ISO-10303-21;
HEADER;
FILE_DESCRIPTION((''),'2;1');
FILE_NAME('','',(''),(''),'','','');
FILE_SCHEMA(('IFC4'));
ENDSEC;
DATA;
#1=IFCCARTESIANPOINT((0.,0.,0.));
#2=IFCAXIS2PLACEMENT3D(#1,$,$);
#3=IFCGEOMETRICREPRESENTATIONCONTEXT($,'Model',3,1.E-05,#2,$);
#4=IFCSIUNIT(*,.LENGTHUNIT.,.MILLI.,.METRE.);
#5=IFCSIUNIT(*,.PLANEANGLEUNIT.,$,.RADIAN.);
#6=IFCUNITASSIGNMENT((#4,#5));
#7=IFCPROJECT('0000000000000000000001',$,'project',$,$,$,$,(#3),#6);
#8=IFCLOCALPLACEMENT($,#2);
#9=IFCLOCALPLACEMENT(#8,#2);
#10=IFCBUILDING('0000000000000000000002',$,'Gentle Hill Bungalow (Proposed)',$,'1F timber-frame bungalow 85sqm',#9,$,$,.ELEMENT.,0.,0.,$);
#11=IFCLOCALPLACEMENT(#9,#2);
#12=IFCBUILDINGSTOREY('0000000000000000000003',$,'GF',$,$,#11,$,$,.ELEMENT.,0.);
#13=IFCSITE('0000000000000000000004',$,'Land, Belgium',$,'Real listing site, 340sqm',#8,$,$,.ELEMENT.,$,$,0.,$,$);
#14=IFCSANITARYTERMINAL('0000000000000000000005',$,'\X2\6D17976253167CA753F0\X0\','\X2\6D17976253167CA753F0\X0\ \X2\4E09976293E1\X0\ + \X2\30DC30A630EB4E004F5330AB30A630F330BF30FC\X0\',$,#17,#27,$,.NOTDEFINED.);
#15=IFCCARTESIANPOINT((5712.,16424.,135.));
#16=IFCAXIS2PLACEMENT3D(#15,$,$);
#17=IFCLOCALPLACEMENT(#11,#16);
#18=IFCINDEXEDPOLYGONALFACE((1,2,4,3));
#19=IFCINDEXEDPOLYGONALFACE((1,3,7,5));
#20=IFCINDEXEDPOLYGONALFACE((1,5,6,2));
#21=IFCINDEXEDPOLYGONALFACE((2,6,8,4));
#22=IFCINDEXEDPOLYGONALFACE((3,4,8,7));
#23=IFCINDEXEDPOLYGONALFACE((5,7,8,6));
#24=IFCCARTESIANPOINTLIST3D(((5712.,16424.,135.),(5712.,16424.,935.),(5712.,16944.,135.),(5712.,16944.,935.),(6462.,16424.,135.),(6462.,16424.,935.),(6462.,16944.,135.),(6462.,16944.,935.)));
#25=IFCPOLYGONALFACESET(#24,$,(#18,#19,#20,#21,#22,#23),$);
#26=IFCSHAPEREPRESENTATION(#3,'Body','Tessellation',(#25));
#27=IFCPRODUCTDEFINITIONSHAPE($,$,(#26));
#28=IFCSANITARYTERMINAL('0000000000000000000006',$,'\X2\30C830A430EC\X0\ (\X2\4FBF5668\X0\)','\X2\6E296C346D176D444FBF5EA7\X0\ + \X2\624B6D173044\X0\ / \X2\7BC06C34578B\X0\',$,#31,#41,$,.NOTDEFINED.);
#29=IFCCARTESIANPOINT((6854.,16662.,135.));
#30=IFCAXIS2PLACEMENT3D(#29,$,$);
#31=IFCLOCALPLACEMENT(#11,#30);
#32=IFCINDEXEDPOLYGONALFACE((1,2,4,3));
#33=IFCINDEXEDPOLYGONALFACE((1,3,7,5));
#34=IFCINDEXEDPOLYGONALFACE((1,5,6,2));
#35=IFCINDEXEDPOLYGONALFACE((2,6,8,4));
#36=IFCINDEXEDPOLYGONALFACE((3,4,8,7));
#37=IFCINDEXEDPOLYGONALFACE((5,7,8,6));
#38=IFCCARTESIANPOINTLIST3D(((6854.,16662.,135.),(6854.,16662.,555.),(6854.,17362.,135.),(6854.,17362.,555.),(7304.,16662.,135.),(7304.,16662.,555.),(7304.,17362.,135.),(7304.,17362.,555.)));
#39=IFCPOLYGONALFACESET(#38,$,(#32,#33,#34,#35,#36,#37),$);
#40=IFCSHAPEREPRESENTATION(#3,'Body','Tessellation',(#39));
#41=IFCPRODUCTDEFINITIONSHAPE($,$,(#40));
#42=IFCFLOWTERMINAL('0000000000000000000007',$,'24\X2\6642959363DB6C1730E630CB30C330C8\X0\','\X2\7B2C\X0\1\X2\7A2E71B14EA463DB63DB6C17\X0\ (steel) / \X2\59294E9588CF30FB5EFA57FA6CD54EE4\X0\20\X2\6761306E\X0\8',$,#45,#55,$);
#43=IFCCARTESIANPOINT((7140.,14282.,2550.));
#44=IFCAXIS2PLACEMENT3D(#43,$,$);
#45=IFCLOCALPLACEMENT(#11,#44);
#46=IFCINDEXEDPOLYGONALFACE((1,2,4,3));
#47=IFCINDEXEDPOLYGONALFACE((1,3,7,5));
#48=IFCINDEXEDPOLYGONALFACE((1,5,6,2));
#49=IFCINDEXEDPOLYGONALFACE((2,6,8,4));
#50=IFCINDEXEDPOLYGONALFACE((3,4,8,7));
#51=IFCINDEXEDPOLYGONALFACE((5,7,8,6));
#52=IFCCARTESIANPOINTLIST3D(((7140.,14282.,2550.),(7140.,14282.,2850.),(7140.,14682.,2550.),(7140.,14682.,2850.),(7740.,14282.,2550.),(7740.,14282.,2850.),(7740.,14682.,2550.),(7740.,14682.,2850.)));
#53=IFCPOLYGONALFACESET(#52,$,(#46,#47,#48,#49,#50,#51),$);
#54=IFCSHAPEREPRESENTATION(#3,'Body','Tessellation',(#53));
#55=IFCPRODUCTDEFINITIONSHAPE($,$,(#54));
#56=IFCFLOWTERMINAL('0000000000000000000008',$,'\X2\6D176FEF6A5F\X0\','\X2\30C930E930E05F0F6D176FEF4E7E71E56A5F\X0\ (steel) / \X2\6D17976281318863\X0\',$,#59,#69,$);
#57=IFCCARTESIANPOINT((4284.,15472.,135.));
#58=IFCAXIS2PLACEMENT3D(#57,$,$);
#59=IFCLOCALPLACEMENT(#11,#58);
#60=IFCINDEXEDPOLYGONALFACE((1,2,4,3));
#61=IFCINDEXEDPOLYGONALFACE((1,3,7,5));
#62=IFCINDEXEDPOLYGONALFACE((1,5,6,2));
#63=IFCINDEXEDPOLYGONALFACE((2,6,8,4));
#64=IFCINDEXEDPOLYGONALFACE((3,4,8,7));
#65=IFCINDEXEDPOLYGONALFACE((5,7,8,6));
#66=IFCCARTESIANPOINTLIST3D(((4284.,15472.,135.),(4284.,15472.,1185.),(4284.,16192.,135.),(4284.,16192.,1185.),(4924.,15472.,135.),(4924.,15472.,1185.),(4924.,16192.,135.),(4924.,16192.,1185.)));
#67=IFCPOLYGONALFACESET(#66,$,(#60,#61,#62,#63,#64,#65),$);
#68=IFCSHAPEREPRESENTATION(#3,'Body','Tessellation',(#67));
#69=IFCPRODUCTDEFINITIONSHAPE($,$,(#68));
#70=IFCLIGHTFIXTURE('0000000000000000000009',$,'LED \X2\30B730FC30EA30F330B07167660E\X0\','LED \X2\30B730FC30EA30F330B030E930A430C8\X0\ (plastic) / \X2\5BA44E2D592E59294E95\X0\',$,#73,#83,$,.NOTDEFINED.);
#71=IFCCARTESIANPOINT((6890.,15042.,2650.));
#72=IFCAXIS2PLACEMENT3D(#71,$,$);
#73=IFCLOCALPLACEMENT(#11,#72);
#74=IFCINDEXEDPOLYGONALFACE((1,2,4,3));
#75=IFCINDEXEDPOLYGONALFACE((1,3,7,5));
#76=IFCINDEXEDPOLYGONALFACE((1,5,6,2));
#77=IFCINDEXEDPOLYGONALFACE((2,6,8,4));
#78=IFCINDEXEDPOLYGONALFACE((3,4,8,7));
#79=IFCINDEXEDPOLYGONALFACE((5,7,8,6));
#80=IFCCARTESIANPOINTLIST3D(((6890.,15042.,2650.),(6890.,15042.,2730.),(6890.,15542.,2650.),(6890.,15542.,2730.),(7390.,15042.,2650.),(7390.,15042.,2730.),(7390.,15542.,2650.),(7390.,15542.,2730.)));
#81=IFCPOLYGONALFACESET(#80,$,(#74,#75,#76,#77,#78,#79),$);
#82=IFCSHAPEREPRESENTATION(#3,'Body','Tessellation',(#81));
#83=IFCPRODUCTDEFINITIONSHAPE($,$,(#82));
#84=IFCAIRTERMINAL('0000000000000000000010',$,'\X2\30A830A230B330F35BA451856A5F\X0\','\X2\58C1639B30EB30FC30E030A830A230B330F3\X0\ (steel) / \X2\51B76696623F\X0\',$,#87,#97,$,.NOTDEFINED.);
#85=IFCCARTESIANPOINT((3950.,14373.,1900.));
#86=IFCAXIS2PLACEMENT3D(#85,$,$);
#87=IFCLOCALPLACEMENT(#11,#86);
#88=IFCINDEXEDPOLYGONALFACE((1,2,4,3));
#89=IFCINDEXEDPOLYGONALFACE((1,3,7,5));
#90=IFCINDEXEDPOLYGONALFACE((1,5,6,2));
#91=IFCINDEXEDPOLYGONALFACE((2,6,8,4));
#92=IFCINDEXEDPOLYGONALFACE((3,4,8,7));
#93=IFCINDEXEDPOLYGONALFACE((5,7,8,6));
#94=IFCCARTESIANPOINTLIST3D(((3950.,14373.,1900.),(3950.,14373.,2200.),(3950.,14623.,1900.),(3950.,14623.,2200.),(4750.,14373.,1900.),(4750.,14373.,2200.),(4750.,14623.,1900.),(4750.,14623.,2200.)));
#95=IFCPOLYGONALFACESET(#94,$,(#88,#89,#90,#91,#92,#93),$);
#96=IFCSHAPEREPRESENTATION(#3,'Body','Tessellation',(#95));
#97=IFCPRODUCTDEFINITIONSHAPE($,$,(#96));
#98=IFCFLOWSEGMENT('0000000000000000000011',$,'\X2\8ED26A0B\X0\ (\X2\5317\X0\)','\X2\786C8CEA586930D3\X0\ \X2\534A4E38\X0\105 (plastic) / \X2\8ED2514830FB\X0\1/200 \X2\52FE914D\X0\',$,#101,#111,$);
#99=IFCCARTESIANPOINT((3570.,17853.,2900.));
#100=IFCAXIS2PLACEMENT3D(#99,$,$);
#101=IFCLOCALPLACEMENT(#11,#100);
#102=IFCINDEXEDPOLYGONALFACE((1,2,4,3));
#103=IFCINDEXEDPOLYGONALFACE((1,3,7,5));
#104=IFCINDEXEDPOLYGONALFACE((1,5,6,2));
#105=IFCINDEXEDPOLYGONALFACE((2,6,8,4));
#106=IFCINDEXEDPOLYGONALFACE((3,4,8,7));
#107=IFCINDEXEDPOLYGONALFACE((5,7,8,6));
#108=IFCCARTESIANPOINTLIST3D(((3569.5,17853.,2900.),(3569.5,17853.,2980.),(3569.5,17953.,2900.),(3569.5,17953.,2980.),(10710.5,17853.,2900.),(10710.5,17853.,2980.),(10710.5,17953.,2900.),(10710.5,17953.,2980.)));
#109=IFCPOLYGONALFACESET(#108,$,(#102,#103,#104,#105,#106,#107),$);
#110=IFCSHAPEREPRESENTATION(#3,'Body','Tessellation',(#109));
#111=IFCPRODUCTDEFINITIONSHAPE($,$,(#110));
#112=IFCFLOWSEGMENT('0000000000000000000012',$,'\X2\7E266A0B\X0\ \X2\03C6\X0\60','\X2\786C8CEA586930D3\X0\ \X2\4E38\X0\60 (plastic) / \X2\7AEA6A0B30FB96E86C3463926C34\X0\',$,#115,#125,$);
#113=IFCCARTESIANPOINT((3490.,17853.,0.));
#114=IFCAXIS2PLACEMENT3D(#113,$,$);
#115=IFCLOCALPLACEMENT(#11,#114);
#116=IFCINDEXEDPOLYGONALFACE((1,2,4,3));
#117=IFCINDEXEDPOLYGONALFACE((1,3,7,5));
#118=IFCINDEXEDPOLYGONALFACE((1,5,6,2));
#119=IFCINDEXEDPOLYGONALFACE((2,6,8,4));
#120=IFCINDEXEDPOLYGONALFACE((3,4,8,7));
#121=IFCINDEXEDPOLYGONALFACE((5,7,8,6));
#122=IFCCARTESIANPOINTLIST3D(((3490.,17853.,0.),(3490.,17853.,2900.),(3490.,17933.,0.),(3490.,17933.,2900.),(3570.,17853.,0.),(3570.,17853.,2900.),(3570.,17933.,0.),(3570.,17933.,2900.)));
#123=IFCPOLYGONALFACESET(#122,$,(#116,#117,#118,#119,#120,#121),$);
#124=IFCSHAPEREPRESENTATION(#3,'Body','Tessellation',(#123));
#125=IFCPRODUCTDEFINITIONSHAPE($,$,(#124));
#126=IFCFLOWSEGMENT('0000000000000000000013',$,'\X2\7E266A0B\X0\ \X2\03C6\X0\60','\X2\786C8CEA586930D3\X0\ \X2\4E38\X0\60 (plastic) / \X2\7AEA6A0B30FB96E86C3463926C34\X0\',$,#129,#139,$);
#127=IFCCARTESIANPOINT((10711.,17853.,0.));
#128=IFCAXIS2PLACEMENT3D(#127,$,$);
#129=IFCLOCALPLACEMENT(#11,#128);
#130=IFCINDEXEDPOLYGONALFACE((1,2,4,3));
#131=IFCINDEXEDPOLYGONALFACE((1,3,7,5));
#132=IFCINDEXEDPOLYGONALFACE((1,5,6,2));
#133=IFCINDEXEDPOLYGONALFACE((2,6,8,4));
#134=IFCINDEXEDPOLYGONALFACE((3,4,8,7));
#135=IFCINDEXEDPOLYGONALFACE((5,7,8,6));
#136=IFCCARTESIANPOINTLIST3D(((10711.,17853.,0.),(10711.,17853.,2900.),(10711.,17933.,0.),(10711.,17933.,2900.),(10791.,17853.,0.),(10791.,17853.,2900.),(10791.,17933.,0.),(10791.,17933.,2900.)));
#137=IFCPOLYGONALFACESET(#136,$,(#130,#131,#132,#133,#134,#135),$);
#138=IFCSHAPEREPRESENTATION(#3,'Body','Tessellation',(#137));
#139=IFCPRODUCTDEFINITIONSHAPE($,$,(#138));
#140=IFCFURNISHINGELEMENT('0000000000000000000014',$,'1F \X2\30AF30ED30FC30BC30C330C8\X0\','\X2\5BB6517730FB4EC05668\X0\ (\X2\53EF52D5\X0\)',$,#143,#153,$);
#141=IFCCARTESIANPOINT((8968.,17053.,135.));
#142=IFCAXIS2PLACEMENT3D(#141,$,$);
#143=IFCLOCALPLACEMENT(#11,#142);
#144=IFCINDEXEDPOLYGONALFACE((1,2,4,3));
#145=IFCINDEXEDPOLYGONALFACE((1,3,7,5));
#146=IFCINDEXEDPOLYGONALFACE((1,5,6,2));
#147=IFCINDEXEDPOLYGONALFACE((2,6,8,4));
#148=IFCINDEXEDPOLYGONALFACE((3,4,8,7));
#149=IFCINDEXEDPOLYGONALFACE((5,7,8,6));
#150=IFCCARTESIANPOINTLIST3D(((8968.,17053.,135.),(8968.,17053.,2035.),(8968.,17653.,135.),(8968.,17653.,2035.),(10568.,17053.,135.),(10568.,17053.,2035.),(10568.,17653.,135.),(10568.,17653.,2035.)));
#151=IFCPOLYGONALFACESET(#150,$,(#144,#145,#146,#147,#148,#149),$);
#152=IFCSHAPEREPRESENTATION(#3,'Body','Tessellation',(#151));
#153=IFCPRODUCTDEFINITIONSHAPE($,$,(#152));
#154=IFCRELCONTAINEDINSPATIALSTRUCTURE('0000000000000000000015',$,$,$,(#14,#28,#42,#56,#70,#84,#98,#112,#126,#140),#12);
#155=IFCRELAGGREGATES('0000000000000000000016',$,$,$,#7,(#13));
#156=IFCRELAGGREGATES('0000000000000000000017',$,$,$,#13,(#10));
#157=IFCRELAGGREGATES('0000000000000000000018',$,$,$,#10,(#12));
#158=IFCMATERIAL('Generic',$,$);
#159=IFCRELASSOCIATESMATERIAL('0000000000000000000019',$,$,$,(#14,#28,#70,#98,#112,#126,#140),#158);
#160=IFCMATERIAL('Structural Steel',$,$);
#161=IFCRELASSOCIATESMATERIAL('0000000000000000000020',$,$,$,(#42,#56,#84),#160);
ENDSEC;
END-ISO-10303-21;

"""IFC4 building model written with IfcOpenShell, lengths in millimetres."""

from ifc_helpers import new_model, si_unit, frame, frame_2d, origin, place, context, project, spatial, rectangle, extrude, material, element, save


model = new_model("IFC4")

# Units and contexts
model_context = context("Model", 3, precision=1e-05, world=origin())
ifc_project = project(units=[si_unit("LENGTHUNIT", "METRE", prefix="MILLI"), si_unit("PLANEANGLEUNIT", "RADIAN")], contexts=[model_context])

# Site, building, storey
site_placement = place(None, origin())
site = spatial("IfcSite", under=ifc_project, at=site_placement, Name="Land, Belgium", ObjectType="Real listing site, 340sqm", CompositionType="ELEMENT", RefElevation=0.0)
building_placement = place(site_placement, origin())
building = spatial("IfcBuilding", under=site, at=building_placement, Name="Gentle Hill Bungalow (Proposed)", ObjectType="1F timber-frame bungalow 85sqm", CompositionType="ELEMENT", ElevationOfRefHeight=0.0, ElevationOfTerrain=0.0)
storey_placement = place(building_placement, origin())
storey = spatial("IfcBuildingStorey", under=building, at=storey_placement, Name="GF", CompositionType="ELEMENT", Elevation=0.0)

# Shared definitions
ifc_material_1 = material(Name="Generic")

# Sanitary terminals
sanitary_terminal_1_placement = place(storey_placement, frame((5712.0, 16424.0, 135.0)))
element("IfcSanitaryTerminal", 1, at=sanitary_terminal_1_placement, inside=storey, material=ifc_material_1, Name="洗面化粧台", Description="洗面化粧台 三面鏡 + ボウル一体カウンター", PredefinedType="NOTDEFINED", context=model_context, shape_type="SweptSolid", body=[
    extrude(rectangle(XDim=750.0, YDim=520.0, at=frame_2d((375.0, 260.0))), frame((5712.0, 16424.0, 135.0)), (0.0, 0.0, 1.0), 800.0),
])
sanitary_terminal_2_placement = place(storey_placement, frame((6854.0, 16662.0, 135.0)))
element("IfcSanitaryTerminal", 2, at=sanitary_terminal_2_placement, inside=storey, material=ifc_material_1, Name="トイレ (便器)", Description="温水洗浄便座 + 手洗い / 節水型", PredefinedType="NOTDEFINED", context=model_context, shape_type="SweptSolid", body=[
    extrude(rectangle(XDim=450.0, YDim=700.0, at=frame_2d((225.0, 350.0))), frame((6854.0, 16662.0, 135.0)), (0.0, 0.0, 1.0), 420.0),
])

# Flow terminals
ifc_material_2 = material(Name="Structural Steel")
flow_terminal_1_placement = place(storey_placement, frame((7140.0, 14282.0, 2550.0)))
element("IfcFlowTerminal", 3, at=flow_terminal_1_placement, inside=storey, material=ifc_material_2, Name="24時間換気ユニット", Description="第1種熱交換換気 (steel) / 天井裏・建基法令20条の8", context=model_context, shape_type="SweptSolid", body=[
    extrude(rectangle(XDim=600.0, YDim=400.0, at=frame_2d((300.0, 200.0))), frame((7140.0, 14282.0, 2550.0)), (0.0, 0.0, 1.0), 300.0),
])
flow_terminal_2_placement = place(storey_placement, frame((4284.0, 15472.0, 135.0)))
element("IfcFlowTerminal", 4, at=flow_terminal_2_placement, inside=storey, material=ifc_material_2, Name="洗濯機", Description="ドラム式洗濯乾燥機 (steel) / 洗面脱衣", context=model_context, shape_type="SweptSolid", body=[
    extrude(rectangle(XDim=640.0, YDim=720.0, at=frame_2d((320.0, 360.0))), frame((4284.0, 15472.0, 135.0)), (0.0, 0.0, 1.0), 1050.0),
])

# Light fixture
light_fixture_placement = place(storey_placement, frame((6890.0, 15042.0, 2650.0)))
element("IfcLightFixture", 5, at=light_fixture_placement, inside=storey, material=ifc_material_1, Name="LED シーリング照明", Description="LED シーリングライト (plastic) / 室中央天井", PredefinedType="NOTDEFINED", context=model_context, shape_type="SweptSolid", body=[
    extrude(rectangle(XDim=500.0, YDim=500.0, at=frame_2d((250.0, 250.0))), frame((6890.0, 15042.0, 2650.0)), (0.0, 0.0, 1.0), 80.0),
])

# Air terminal
air_terminal_placement = place(storey_placement, frame((3950.0, 14373.0, 1900.0)))
element("IfcAirTerminal", 6, at=air_terminal_placement, inside=storey, material=ifc_material_2, Name="エアコン室内機", Description="壁掛ルームエアコン (steel) / 冷暖房", PredefinedType="NOTDEFINED", context=model_context, shape_type="SweptSolid", body=[
    extrude(rectangle(XDim=800.0, YDim=250.0, at=frame_2d((400.0, 125.0))), frame((3950.0, 14373.0, 1900.0)), (0.0, 0.0, 1.0), 300.0),
])

# Flow segments
flow_segment_1_placement = place(storey_placement, frame((3570.0, 17853.0, 2900.0)))
element("IfcFlowSegment", 7, at=flow_segment_1_placement, inside=storey, material=ifc_material_1, Name="軒樋 (北)", Description="硬質塩ビ 半丸105 (plastic) / 軒先・1/200 勾配", context=model_context, shape_type="SweptSolid", body=[
    extrude(rectangle(XDim=7141.0, YDim=100.0, at=frame_2d((3570.0, 50.0))), frame((3570.0, 17853.0, 2900.0)), (0.0, 0.0, 1.0), 80.0),
])
flow_segment_2_placement = place(storey_placement, frame((3490.0, 17853.0, 0.0)))
element("IfcFlowSegment", 8, at=flow_segment_2_placement, inside=storey, material=ifc_material_1, Name="縦樋 φ60", Description="硬質塩ビ 丸60 (plastic) / 竪樋・雨水排水", context=model_context, shape_type="SweptSolid", body=[
    extrude(rectangle(XDim=80.0, YDim=80.0, at=frame_2d((40.0, 40.0))), frame((3490.0, 17853.0, 0.0)), (0.0, 0.0, 1.0), 2900.0),
])
flow_segment_3_placement = place(storey_placement, frame((10711.0, 17853.0, 0.0)))
element("IfcFlowSegment", 9, at=flow_segment_3_placement, inside=storey, material=ifc_material_1, Name="縦樋 φ60", Description="硬質塩ビ 丸60 (plastic) / 竪樋・雨水排水", context=model_context, shape_type="SweptSolid", body=[
    extrude(rectangle(XDim=80.0, YDim=80.0, at=frame_2d((40.0, 40.0))), frame((10711.0, 17853.0, 0.0)), (0.0, 0.0, 1.0), 2900.0),
])

# Furnishing element
furnishing_placement = place(storey_placement, frame((8968.0, 17053.0, 135.0)))
element("IfcFurnishingElement", 10, at=furnishing_placement, inside=storey, material=ifc_material_1, Name="1F クローゼット", Description="家具・什器 (可動)", context=model_context, shape_type="SweptSolid", body=[
    extrude(rectangle(XDim=1600.0, YDim=600.0, at=frame_2d((800.0, 300.0))), frame((8968.0, 17053.0, 135.0)), (0.0, 0.0, 1.0), 1900.0),
])

save(model, "model.ifc")
